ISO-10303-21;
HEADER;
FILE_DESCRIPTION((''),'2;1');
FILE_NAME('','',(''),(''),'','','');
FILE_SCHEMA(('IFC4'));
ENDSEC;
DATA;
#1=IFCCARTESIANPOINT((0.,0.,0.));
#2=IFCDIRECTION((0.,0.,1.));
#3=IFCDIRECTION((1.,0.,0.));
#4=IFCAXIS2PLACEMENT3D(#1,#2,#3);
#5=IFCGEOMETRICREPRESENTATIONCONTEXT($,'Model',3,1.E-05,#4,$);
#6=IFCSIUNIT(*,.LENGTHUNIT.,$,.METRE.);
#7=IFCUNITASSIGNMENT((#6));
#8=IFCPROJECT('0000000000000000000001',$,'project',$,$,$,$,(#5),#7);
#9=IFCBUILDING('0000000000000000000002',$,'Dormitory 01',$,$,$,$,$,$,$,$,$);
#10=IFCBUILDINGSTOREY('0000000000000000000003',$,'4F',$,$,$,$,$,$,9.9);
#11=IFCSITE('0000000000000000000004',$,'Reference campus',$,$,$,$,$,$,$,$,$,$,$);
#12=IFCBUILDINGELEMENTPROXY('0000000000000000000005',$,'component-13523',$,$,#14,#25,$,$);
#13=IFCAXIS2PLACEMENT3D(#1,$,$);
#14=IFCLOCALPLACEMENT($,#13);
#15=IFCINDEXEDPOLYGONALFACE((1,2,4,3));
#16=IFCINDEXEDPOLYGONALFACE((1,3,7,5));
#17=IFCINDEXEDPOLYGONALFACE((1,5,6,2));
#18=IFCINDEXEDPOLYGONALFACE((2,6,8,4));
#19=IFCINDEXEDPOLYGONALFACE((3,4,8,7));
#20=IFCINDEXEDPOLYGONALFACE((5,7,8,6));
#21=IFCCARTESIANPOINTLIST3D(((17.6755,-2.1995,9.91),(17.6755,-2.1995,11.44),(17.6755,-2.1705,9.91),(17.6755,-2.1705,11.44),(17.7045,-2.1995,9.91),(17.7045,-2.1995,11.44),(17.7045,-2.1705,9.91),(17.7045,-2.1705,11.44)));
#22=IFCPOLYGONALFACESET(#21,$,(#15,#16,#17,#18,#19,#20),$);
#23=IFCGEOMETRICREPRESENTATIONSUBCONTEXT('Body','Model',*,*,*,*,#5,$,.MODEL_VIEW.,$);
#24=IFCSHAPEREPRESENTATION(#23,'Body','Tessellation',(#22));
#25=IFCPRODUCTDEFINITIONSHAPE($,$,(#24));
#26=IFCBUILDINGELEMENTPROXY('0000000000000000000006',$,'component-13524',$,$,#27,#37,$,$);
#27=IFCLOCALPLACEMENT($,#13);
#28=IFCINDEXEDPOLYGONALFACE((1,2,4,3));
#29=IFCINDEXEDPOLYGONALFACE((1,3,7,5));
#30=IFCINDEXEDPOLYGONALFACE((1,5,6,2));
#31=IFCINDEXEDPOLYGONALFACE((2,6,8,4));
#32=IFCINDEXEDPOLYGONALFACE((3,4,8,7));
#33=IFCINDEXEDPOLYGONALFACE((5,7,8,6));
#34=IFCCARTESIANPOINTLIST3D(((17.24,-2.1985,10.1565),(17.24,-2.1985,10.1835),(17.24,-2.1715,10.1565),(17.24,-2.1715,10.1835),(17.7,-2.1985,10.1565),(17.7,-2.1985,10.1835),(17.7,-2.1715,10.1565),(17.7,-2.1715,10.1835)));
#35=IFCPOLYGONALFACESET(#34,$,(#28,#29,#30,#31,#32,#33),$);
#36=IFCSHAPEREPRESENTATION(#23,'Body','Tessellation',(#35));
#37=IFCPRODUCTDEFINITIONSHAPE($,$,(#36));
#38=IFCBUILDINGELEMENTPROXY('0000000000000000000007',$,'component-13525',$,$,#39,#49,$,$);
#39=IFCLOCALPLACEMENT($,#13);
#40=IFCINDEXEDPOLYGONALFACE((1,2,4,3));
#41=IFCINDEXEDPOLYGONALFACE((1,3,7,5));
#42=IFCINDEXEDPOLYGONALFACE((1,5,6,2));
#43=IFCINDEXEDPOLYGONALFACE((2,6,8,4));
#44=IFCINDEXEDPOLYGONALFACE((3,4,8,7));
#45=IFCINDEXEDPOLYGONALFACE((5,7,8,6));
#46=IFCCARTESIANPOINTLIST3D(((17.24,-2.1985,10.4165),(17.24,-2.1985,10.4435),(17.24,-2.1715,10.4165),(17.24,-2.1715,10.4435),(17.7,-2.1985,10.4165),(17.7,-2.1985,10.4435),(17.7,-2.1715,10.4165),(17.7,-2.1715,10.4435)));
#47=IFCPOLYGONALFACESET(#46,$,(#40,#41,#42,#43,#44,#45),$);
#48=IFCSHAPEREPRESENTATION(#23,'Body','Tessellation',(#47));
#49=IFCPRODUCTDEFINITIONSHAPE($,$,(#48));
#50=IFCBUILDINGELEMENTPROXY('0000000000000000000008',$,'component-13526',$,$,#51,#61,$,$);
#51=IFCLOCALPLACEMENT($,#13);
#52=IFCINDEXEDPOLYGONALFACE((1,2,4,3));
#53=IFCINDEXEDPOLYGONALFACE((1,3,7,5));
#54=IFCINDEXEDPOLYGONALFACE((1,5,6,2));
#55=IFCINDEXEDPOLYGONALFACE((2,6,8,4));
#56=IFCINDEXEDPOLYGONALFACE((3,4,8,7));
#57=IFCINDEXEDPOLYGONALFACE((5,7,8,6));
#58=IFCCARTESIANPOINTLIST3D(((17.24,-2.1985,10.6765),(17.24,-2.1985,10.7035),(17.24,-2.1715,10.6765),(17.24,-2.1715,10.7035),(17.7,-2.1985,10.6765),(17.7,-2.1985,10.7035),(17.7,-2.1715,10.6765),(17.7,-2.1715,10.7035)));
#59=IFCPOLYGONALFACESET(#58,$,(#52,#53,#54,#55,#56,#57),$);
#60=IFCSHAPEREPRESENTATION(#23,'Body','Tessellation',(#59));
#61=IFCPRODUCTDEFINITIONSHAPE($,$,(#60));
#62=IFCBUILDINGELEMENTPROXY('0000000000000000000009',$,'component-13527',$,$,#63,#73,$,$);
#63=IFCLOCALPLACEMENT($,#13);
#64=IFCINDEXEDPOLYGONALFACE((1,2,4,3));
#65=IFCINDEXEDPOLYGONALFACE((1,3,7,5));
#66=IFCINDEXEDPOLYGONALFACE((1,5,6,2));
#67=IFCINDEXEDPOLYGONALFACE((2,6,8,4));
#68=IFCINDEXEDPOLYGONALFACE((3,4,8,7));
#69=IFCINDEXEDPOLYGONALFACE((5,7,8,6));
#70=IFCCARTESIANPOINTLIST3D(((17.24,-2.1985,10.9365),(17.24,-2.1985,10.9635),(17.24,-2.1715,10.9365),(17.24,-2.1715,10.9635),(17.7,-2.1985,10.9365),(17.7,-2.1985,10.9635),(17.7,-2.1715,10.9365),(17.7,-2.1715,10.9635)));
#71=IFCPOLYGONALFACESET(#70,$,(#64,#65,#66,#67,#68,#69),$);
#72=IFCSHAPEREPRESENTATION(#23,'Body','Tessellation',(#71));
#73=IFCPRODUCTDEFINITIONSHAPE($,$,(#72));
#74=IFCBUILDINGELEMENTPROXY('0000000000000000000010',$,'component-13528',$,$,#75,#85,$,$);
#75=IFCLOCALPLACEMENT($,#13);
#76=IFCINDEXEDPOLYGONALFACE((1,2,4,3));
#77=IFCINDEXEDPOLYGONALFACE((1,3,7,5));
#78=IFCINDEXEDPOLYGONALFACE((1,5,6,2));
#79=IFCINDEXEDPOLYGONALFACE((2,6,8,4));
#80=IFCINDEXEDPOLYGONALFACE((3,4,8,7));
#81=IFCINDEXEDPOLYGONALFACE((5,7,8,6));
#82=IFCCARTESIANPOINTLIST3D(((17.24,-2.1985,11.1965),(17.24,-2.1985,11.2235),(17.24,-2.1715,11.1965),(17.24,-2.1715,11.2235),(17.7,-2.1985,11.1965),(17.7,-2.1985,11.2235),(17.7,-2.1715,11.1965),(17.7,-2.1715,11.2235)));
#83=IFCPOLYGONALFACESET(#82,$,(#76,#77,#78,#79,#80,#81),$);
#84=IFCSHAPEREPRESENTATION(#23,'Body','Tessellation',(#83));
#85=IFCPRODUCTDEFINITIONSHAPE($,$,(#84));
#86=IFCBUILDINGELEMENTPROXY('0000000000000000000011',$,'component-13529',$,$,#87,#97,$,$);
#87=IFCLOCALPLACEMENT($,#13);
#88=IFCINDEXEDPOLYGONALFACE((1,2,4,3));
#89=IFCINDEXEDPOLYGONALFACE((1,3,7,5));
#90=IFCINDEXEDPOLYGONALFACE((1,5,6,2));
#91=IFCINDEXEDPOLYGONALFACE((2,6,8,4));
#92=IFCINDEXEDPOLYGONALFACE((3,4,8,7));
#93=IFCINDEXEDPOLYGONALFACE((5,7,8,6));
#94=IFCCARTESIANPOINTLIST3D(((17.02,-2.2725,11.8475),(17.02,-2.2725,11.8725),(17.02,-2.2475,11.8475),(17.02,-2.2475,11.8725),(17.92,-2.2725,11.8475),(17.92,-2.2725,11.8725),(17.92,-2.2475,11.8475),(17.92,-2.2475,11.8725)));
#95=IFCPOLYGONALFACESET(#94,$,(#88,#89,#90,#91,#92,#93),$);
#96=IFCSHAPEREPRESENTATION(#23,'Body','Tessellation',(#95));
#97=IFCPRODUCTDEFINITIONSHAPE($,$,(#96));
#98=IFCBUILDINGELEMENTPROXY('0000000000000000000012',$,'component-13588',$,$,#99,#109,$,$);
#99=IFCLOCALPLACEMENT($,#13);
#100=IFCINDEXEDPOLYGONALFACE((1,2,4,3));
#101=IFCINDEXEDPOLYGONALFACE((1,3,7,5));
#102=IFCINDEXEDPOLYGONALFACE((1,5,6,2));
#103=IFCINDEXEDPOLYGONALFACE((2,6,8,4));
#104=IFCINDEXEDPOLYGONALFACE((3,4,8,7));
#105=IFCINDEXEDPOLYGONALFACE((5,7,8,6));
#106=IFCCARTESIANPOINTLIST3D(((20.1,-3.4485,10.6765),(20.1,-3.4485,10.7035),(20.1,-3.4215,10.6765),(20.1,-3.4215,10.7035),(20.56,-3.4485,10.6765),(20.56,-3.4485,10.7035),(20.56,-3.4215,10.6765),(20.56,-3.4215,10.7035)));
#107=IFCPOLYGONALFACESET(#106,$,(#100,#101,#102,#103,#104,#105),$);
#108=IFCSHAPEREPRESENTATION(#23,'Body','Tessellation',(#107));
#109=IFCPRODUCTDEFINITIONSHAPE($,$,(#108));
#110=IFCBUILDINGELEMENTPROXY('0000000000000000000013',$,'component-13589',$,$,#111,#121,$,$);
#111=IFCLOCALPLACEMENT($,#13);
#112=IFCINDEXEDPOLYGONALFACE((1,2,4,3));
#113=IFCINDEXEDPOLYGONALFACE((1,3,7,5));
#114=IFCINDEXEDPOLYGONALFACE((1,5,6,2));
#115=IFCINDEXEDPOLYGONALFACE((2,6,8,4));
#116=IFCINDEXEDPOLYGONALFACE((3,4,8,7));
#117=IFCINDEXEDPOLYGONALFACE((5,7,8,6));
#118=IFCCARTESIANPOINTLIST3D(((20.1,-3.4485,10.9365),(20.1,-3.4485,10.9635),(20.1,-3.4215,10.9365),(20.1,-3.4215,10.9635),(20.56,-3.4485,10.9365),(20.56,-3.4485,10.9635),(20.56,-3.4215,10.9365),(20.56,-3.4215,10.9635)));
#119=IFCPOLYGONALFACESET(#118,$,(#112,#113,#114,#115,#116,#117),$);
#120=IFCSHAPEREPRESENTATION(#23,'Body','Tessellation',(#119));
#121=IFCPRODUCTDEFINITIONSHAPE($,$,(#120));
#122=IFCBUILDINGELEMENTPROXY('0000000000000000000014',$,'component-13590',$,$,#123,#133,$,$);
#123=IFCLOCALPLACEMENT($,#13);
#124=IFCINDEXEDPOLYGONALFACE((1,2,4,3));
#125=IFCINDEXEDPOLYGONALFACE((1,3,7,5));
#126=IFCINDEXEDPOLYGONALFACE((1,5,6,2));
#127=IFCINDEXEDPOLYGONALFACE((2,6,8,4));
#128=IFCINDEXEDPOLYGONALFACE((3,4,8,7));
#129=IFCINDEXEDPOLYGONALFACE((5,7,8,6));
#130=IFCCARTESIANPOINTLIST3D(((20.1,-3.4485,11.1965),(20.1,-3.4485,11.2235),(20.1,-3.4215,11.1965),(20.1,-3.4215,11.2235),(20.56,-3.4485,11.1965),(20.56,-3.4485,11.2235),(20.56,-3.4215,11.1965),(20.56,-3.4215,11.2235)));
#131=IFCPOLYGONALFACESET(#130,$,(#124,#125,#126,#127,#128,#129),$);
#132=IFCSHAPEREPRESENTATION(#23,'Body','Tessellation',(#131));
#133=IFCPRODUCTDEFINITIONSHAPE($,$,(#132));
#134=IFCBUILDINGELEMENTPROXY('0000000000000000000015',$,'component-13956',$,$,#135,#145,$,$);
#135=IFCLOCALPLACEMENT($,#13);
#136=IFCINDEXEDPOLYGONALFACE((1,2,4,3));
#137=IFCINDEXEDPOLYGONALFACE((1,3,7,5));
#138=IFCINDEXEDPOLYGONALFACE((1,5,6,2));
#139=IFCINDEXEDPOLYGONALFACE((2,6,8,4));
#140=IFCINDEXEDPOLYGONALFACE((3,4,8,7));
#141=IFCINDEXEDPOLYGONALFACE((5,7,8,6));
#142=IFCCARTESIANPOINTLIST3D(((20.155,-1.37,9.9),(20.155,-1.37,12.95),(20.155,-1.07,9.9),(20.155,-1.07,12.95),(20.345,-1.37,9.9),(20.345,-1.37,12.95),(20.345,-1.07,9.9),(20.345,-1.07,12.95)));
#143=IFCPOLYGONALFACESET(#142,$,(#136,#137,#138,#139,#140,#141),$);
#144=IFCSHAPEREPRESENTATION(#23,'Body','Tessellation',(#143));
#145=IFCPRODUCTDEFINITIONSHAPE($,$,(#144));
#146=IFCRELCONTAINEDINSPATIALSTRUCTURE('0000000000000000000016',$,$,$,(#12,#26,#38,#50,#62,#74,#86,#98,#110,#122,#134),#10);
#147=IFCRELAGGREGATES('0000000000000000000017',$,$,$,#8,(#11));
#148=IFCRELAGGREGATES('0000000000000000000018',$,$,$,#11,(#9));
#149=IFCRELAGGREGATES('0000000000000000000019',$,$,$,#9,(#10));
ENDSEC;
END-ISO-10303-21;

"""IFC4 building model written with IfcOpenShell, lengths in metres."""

from ifc_helpers import new_model, si_unit, frame, origin, origin_with_axes, origin_2d, place, context, subcontext, project, spatial, rectangle, extrude, element, save


model = new_model("IFC4")

# Units and contexts
model_context = context("Model", 3, precision=1e-05, world=origin_with_axes())
body_context = subcontext(model_context, "Body", "Model", "MODEL_VIEW")
ifc_project = project(units=[si_unit("LENGTHUNIT", "METRE")], contexts=[model_context])

# Site, building, storey
site = spatial("IfcSite", under=ifc_project, Name="Reference campus")
building = spatial("IfcBuilding", under=site, Name="Dormitory 01")
storey = spatial("IfcBuildingStorey", under=building, Name="4F", Elevation=9.9)

# Building element proxies
proxy_1_placement = place(None, frame((17.69, -2.185, 9.91), z_axis=(0.0, 0.0, 1.0), x_axis=(1.0, 0.0, 0.0)))
element("IfcBuildingElementProxy", 1, at=proxy_1_placement, inside=storey, Name="component-13523", context=body_context, shape_type="SweptSolid", body=[
    extrude(rectangle(XDim=0.029, YDim=0.029, at=origin_2d()), origin(), (0.0, 0.0, 1.0), 1.53),
])
for number, where, z_axis, x_axis, name in (
    (2, (17.47, -2.185, 10.1565), (0.0, 0.0, 1.0), (1.0, 0.0, 0.0), "component-13524"),
    (3, (17.47, -2.185, 10.4165), (0.0, 0.0, 1.0), (1.0, 0.0, 0.0), "component-13525"),
    (4, (17.47, -2.185, 10.6765), (0.0, 0.0, 1.0), (1.0, 0.0, 0.0), "component-13526"),
    (5, (17.47, -2.185, 10.9365), (0.0, 0.0, 1.0), (1.0, 0.0, 0.0), "component-13527"),
    (6, (17.47, -2.185, 11.1965), (0.0, 0.0, 1.0), (1.0, 0.0, 0.0), "component-13528"),
):
    element("IfcBuildingElementProxy", number, at=place(None, frame(where, z_axis=z_axis, x_axis=x_axis)), inside=storey, Name=name, context=body_context, shape_type="SweptSolid", body=[
        extrude(rectangle(XDim=0.46, YDim=0.027, at=origin_2d()), origin(), (0.0, 0.0, 1.0), 0.027),
    ])
proxy_2_placement = place(None, frame((17.47, -2.26, 11.8475), z_axis=(0.0, 0.0, 1.0), x_axis=(1.0, 0.0, 0.0)))
element("IfcBuildingElementProxy", 7, at=proxy_2_placement, inside=storey, Name="component-13529", context=body_context, shape_type="SweptSolid", body=[
    extrude(rectangle(XDim=0.9, YDim=0.025, at=origin_2d()), origin(), (0.0, 0.0, 1.0), 0.025),
])
for number, where, z_axis, x_axis, name in (
    (8, (20.33, -3.435, 10.6765), (0.0, 0.0, 1.0), (1.0, 0.0, 0.0), "component-13588"),
    (9, (20.33, -3.435, 10.9365), (0.0, 0.0, 1.0), (1.0, 0.0, 0.0), "component-13589"),
    (10, (20.33, -3.435, 11.1965), (0.0, 0.0, 1.0), (1.0, 0.0, 0.0), "component-13590"),
):
    element("IfcBuildingElementProxy", number, at=place(None, frame(where, z_axis=z_axis, x_axis=x_axis)), inside=storey, Name=name, context=body_context, shape_type="SweptSolid", body=[
        extrude(rectangle(XDim=0.46, YDim=0.027, at=origin_2d()), origin(), (0.0, 0.0, 1.0), 0.027),
    ])
proxy_3_placement = place(None, frame((20.25, -1.22, 9.9), z_axis=(0.0, 0.0, 1.0), x_axis=(1.0, 0.0, 0.0)))
element("IfcBuildingElementProxy", 11, at=proxy_3_placement, inside=storey, Name="component-13956", context=body_context, shape_type="SweptSolid", body=[
    extrude(rectangle(XDim=0.19, YDim=0.3, at=origin_2d()), origin(), (0.0, 0.0, 1.0), 3.05),
])

save(model, "model.ifc")
